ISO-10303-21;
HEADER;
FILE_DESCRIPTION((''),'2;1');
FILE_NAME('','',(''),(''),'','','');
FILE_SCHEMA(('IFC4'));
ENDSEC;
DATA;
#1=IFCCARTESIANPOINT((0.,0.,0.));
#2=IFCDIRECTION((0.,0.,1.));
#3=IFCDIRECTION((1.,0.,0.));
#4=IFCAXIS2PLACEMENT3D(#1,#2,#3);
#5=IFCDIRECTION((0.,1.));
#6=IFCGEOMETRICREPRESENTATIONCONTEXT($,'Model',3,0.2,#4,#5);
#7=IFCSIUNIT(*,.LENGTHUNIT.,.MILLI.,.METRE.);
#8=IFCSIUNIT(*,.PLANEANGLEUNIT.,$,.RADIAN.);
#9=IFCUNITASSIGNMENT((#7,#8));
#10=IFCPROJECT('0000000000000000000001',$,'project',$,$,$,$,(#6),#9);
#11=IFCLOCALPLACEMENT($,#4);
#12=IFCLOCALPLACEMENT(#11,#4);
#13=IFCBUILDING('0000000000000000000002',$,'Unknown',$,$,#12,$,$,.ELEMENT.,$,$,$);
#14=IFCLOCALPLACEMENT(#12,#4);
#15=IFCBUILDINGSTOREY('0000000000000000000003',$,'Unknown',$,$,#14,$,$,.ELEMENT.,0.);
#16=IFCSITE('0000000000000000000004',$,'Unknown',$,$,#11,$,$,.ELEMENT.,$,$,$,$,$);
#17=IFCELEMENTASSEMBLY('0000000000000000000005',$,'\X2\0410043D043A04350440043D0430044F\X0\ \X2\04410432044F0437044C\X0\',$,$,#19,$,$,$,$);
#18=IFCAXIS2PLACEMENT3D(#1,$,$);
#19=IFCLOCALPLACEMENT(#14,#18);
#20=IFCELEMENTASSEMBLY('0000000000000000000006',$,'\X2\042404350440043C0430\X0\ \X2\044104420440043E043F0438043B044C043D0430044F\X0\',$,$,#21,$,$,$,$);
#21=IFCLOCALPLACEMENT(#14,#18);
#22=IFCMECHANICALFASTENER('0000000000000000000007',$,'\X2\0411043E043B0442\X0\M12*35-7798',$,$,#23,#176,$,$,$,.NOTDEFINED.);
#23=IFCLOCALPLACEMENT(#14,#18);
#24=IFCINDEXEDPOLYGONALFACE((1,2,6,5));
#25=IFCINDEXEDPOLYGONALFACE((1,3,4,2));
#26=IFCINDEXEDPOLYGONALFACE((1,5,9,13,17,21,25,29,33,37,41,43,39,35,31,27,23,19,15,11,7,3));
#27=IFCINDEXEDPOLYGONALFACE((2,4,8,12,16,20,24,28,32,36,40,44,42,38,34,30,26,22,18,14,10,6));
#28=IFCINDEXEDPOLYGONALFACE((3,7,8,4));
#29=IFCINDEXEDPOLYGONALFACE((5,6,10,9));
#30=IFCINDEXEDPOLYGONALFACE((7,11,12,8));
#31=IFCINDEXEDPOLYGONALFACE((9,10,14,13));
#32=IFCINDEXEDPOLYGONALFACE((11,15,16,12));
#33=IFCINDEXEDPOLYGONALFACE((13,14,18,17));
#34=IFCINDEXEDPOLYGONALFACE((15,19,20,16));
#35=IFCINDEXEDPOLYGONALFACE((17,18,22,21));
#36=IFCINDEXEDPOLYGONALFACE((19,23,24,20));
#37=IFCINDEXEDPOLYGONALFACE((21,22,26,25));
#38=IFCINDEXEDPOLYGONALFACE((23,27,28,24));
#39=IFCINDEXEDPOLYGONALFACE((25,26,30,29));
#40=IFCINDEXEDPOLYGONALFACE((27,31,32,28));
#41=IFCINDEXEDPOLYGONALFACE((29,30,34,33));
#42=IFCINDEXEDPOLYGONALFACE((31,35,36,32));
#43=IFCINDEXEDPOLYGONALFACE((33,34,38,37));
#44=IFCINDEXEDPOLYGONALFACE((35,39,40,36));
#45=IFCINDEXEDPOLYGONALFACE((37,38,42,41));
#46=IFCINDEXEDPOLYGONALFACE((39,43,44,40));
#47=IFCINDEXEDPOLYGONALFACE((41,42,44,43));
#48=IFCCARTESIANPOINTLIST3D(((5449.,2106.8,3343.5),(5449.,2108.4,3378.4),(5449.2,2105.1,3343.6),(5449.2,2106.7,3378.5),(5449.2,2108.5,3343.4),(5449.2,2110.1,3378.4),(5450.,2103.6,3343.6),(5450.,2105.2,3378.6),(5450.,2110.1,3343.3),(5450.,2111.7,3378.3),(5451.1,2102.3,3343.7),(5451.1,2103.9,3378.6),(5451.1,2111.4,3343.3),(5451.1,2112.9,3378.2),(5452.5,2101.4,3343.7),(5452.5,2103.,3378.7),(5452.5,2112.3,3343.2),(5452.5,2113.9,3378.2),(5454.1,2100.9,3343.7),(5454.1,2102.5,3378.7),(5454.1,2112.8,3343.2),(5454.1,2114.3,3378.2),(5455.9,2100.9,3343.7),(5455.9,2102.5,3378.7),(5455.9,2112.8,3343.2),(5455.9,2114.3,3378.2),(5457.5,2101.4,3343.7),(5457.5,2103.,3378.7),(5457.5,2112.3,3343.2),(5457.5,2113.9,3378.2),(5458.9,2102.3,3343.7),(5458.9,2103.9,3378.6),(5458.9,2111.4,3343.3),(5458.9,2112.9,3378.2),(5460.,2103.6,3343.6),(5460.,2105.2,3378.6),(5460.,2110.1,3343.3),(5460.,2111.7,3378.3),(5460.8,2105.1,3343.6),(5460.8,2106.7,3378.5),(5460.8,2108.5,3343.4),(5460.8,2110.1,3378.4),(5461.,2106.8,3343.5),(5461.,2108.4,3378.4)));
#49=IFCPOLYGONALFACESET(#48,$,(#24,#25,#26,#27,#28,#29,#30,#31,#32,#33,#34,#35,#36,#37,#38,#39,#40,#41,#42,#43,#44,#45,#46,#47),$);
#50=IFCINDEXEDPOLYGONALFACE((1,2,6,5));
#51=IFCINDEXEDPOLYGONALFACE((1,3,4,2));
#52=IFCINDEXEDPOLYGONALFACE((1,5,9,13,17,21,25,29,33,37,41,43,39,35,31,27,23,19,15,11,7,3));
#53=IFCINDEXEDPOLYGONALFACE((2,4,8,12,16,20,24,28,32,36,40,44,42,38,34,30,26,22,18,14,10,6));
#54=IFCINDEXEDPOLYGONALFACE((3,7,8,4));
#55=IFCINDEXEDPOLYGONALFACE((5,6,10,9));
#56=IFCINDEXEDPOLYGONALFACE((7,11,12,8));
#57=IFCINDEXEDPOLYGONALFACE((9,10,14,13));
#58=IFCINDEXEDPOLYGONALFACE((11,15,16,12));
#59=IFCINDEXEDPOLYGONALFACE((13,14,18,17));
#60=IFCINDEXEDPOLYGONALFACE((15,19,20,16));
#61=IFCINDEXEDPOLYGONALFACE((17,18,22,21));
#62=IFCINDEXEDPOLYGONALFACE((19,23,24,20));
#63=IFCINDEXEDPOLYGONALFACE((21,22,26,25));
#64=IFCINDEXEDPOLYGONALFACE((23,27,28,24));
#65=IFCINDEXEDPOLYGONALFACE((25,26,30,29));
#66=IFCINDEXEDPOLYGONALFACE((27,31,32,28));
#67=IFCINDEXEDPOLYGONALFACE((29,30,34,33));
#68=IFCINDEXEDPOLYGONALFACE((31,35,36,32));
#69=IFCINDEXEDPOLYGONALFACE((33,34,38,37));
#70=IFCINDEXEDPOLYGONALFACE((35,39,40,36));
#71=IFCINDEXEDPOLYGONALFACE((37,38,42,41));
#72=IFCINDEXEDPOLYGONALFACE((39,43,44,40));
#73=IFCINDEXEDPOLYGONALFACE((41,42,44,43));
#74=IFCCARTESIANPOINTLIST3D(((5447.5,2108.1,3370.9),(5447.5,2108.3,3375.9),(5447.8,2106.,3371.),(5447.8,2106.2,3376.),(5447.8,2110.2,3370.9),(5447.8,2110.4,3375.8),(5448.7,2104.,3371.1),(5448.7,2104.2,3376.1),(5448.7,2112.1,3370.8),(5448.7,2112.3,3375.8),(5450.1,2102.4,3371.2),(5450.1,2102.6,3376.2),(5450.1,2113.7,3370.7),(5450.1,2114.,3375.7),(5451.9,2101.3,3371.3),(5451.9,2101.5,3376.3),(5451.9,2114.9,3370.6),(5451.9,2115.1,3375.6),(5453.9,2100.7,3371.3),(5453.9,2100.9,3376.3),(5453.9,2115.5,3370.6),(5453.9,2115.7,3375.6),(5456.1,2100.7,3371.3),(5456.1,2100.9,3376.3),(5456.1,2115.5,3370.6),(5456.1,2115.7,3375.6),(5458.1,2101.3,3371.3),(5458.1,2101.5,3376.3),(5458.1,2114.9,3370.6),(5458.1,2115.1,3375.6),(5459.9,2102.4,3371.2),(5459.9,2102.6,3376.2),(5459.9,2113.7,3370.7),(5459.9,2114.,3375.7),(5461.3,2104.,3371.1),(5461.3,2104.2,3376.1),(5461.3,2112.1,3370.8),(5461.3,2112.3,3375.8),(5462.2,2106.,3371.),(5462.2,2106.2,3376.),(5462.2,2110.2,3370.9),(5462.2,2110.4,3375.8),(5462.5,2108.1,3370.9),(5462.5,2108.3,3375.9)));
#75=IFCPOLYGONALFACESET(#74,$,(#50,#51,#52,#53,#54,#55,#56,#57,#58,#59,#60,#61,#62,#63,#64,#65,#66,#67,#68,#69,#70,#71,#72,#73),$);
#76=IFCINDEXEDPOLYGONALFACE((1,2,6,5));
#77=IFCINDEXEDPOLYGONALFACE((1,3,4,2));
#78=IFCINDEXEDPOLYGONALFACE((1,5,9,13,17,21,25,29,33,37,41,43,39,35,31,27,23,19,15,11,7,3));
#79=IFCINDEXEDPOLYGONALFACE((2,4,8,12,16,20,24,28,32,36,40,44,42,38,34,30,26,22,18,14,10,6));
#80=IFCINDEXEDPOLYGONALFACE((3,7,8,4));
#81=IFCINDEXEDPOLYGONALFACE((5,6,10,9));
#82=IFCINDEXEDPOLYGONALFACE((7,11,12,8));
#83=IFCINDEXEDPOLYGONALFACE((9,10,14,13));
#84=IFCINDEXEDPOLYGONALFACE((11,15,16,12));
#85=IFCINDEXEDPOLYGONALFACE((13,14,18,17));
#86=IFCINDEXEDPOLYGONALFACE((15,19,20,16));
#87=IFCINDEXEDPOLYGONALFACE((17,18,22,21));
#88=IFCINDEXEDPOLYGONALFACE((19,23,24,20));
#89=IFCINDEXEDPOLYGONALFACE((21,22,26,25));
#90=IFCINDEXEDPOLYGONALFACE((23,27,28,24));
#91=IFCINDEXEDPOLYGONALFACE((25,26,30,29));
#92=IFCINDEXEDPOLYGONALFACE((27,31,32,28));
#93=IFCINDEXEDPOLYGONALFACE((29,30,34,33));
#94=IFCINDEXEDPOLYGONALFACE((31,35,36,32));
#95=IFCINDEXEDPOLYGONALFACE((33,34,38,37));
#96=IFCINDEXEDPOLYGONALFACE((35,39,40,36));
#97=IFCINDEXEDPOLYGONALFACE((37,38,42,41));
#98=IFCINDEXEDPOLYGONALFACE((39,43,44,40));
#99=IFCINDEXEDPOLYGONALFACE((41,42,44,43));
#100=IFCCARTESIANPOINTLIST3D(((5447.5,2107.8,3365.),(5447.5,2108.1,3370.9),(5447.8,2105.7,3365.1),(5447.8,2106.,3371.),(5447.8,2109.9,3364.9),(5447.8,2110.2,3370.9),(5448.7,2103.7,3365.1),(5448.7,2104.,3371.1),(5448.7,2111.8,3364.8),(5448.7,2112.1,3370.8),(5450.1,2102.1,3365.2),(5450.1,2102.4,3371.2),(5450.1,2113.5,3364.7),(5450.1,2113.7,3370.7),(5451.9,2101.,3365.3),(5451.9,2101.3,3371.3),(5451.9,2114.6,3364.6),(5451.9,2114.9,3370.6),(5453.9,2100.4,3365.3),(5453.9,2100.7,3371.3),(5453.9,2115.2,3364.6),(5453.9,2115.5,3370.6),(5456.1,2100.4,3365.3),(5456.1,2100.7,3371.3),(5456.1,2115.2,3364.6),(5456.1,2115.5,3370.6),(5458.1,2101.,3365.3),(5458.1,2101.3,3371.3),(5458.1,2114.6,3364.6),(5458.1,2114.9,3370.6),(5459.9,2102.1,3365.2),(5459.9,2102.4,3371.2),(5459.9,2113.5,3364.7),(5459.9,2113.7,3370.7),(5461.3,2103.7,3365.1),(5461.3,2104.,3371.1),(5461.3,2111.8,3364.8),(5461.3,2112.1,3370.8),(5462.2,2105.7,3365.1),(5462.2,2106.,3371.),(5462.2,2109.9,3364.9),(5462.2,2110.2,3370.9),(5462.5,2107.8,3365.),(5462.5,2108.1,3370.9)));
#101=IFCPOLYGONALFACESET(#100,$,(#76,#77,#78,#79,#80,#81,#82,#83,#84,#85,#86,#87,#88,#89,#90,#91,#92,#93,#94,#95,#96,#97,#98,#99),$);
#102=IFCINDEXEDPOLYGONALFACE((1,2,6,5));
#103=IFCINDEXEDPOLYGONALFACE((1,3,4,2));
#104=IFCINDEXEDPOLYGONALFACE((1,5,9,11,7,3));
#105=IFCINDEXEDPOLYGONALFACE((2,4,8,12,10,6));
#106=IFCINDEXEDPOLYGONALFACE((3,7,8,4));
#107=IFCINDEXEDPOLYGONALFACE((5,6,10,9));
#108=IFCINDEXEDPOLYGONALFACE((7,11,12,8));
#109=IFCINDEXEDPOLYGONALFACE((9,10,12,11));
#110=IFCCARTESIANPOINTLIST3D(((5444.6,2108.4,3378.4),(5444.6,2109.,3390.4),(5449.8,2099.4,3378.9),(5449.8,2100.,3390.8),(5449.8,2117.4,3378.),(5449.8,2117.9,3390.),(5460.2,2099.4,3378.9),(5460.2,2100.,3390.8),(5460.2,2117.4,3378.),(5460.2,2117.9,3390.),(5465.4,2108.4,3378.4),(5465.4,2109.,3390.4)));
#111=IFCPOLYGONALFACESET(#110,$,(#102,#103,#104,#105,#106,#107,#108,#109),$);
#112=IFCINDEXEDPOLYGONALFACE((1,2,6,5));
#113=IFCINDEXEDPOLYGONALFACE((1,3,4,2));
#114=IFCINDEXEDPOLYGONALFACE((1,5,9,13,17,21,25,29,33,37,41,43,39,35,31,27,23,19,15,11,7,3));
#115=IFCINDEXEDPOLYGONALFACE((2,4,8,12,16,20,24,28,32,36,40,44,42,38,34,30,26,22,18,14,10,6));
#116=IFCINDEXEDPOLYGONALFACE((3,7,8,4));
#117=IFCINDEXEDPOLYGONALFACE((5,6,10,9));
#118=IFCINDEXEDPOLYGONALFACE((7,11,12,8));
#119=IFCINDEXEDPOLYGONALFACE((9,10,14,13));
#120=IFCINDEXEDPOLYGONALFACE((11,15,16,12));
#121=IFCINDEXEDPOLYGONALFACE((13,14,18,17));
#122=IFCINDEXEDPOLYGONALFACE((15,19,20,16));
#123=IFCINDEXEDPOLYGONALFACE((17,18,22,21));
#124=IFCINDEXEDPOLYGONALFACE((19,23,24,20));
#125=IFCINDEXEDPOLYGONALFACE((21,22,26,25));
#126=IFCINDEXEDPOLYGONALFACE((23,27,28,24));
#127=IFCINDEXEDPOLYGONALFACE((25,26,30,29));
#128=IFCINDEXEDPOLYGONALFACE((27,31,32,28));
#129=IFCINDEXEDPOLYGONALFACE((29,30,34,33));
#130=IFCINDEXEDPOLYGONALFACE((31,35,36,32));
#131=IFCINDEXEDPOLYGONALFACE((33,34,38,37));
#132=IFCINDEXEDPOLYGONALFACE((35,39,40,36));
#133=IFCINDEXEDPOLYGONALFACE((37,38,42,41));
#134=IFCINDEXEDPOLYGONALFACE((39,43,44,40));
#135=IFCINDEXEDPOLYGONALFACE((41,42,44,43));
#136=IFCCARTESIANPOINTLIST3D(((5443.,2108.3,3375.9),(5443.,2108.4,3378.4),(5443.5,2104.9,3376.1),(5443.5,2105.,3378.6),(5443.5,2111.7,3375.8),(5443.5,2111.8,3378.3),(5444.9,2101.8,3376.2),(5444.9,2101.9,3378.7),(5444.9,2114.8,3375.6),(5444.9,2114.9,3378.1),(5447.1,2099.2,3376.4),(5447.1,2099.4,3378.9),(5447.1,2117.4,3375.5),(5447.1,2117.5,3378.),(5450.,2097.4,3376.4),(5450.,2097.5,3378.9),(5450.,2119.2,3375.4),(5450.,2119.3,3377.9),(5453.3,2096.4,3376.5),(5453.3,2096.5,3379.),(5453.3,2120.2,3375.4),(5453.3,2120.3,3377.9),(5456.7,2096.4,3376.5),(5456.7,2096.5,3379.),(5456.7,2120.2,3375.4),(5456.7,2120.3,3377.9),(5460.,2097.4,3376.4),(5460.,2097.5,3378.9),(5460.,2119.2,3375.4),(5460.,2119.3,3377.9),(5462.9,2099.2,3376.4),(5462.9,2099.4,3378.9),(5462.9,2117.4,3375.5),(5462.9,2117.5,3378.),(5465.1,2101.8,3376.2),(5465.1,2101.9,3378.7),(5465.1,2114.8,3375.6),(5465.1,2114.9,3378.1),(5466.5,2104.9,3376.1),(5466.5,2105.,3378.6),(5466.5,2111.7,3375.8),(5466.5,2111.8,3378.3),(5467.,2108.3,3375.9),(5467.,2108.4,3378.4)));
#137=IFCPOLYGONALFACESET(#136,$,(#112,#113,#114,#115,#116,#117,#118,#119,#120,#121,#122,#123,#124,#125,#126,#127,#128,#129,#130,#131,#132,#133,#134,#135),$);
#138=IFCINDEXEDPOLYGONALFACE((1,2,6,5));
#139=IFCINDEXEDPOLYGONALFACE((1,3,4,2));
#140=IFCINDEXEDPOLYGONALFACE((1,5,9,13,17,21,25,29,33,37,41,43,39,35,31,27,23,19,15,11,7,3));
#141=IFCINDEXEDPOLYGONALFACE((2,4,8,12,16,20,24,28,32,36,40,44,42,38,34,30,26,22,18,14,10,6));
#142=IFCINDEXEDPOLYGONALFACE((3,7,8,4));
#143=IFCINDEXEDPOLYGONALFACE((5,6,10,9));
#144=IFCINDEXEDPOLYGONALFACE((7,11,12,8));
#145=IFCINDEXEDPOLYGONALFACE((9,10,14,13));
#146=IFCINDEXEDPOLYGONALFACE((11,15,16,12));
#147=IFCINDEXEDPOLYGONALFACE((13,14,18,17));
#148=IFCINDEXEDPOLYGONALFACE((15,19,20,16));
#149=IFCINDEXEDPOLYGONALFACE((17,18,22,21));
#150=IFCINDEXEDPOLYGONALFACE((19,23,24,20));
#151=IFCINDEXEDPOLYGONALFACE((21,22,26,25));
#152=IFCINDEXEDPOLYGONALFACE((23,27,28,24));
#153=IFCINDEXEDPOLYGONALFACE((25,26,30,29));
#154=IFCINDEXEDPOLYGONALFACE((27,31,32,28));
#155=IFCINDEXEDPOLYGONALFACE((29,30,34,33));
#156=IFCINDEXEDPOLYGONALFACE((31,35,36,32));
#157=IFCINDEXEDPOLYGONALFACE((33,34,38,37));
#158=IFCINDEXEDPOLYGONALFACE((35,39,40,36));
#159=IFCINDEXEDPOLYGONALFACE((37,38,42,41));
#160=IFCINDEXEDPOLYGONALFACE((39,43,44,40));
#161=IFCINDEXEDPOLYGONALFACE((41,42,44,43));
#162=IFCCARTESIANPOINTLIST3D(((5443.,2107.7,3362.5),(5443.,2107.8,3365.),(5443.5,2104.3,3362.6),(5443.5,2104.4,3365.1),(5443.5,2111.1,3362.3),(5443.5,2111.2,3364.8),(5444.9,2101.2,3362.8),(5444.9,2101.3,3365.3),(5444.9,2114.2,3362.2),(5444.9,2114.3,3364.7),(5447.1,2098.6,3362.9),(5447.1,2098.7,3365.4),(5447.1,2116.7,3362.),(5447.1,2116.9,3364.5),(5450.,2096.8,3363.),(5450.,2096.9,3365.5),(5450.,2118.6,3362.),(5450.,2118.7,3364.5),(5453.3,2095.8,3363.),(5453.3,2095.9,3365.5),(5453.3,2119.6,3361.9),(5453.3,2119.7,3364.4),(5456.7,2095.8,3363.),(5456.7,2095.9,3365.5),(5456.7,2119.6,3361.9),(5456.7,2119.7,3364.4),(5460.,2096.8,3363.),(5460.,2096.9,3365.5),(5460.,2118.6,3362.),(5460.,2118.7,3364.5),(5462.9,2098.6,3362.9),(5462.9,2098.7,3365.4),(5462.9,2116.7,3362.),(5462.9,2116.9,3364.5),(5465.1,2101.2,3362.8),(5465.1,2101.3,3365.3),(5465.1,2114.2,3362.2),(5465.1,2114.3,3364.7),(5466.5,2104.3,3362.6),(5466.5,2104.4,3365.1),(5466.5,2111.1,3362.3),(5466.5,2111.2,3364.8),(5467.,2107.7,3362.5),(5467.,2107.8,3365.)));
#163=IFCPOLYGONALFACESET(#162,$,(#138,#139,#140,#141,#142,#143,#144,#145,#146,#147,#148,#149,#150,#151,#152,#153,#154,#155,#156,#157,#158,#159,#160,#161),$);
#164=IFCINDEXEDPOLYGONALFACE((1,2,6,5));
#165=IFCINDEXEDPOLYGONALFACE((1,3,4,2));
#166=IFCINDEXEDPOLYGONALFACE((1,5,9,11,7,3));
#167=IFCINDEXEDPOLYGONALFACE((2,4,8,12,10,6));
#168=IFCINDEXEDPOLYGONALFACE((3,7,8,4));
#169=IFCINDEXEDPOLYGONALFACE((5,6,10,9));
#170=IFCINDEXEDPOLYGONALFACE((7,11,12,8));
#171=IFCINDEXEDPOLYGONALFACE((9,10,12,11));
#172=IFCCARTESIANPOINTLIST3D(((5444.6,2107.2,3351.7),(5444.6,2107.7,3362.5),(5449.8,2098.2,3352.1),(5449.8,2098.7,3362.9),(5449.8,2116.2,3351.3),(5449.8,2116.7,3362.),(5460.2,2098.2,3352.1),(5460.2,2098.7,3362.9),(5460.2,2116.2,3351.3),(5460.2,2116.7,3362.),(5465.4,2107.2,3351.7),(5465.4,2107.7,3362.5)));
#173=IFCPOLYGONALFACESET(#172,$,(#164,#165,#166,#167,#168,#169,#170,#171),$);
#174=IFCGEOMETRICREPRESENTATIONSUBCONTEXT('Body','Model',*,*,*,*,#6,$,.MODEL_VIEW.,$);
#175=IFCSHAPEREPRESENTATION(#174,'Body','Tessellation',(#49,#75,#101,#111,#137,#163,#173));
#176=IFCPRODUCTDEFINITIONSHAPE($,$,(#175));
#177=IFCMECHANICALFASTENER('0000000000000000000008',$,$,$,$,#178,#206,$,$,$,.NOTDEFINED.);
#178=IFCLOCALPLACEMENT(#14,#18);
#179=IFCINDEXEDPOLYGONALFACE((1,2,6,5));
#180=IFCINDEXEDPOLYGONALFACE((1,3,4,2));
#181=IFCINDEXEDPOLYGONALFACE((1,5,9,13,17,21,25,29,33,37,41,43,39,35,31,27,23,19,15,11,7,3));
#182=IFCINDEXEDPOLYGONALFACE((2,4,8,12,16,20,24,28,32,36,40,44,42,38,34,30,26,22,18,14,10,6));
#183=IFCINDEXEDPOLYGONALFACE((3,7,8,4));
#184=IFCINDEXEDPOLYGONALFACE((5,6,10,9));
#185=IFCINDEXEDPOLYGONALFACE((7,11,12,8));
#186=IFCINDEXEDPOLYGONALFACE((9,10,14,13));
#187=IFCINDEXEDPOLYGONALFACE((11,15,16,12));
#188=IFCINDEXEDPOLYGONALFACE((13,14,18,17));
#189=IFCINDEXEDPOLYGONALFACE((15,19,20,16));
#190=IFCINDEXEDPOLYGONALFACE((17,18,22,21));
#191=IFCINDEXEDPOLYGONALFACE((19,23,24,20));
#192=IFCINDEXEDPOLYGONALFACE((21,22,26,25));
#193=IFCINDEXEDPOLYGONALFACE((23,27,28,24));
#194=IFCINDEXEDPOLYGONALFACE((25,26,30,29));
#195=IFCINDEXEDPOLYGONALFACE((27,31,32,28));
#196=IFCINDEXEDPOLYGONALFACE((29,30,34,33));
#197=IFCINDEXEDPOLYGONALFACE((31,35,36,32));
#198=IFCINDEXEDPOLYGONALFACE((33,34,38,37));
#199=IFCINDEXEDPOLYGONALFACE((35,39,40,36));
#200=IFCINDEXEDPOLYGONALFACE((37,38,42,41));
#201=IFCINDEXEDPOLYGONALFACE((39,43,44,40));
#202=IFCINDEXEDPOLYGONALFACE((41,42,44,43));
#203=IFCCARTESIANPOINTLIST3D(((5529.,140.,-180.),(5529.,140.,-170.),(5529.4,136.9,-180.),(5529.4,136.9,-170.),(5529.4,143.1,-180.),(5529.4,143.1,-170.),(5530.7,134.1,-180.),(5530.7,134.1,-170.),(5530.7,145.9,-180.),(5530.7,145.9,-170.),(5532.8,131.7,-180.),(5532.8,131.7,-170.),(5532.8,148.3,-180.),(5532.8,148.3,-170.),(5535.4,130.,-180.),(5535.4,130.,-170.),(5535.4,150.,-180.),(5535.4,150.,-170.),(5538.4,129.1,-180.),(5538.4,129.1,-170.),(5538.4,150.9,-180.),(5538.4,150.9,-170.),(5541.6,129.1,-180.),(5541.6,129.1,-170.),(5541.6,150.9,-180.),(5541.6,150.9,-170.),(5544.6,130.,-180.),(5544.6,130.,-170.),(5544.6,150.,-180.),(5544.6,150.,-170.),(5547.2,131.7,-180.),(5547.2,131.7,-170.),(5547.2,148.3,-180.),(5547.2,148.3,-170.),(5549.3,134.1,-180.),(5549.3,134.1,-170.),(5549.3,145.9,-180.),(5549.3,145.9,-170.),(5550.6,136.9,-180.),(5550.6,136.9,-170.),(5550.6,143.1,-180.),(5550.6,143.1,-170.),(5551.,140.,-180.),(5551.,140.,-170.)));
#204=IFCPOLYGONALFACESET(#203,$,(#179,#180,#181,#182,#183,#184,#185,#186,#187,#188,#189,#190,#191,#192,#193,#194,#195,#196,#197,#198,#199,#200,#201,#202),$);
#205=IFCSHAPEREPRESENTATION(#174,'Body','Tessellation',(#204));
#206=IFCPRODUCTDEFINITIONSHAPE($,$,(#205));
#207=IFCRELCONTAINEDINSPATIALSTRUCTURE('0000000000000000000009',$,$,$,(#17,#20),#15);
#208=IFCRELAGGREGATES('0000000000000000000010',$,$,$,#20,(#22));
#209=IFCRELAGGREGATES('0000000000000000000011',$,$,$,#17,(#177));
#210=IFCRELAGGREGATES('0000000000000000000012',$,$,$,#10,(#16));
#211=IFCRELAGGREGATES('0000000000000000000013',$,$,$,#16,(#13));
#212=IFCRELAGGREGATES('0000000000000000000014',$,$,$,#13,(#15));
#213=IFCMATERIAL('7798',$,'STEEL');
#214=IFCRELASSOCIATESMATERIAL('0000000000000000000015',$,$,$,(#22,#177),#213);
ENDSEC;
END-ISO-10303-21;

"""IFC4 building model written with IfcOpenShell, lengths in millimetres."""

from ifc_helpers import new_model, si_unit, direction, frame, origin_with_axes, place, context, subcontext, project, spatial, line, arc, indexed_curve, outline, extrude, source, transform, mapped, material, element, aggregate, save


model = new_model("IFC4")

# Units and contexts
model_context = context("Model", 3, precision=0.2, world=origin_with_axes(), true_north=direction((0.0, 1.0)))
body_context = subcontext(model_context, "Body", "Model", "MODEL_VIEW")
ifc_project = project(units=[si_unit("LENGTHUNIT", "METRE", prefix="MILLI"), si_unit("PLANEANGLEUNIT", "RADIAN")], contexts=[model_context])

# Site, building, storey
site_placement = place(None, origin_with_axes())
site = spatial("IfcSite", under=ifc_project, at=site_placement, Name="Unknown", CompositionType="ELEMENT")
building_placement = place(site_placement, origin_with_axes())
building = spatial("IfcBuilding", under=site, at=building_placement, Name="Unknown", CompositionType="ELEMENT")
storey_placement = place(building_placement, origin_with_axes())
storey = spatial("IfcBuildingStorey", under=building, at=storey_placement, Name="Unknown", CompositionType="ELEMENT", Elevation=0.0)

# Element assembly
assembly_1_placement = place(storey_placement, frame((5540.0, 140.0, -125.0), z_axis=(-1.0, 0.0, 0.0), x_axis=(0.0, 0.0, -1.0)))
assembly_1 = element("IfcElementAssembly", 1, at=assembly_1_placement, inside=storey, Name="Анкерная связь")

# Element assembly
assembly_2_placement = place(storey_placement, frame((5400.0, 88.6, 3426.7), z_axis=(1.0, 0.0, 0.0), x_axis=(0.0, 0.998969, -0.045408)))
assembly_2 = element("IfcElementAssembly", 2, at=assembly_2_placement, inside=storey, Name="Ферма стропильная")

# Mechanical fasteners
ifc_material_1 = material(Name="7798", Category="STEEL")
shared_shape_1 = source(origin_with_axes(), body_context, "Body", "SweptSolid", [
    extrude(outline(indexed_curve([(6.0, 0.0), (0.0, 6.0), (-6.0, 0.0), (0.0, -6.0)], segments=[arc(1, 2, 3), arc(3, 4, 1)])), frame((0.0, 0.0, 7.5), z_axis=(0.0, 0.0, -1.0), x_axis=(0.0, 1.0, 0.0)), (0.0, 0.0, 1.0), 35.0),
    extrude(outline(indexed_curve([(7.5, 0.0), (0.0, 7.5), (-7.5, 0.0), (0.0, -7.5)], segments=[arc(1, 2, 3), arc(3, 4, 1)])), frame((0.0, 0.0, 5.0), z_axis=(0.0, 0.0, -1.0), x_axis=(0.0, 1.0, 0.0)), (0.0, 0.0, 1.0), 5.0),
    extrude(outline(indexed_curve([(7.5, 0.0), (0.0, 7.5), (-7.5, 0.0), (0.0, -7.5)], segments=[arc(1, 2, 3), arc(3, 4, 1)])), frame((0.0, 0.0, 0.0), z_axis=(0.0, 0.0, -1.0), x_axis=(0.0, 1.0, 0.0)), (0.0, 0.0, 1.0), 6.0),
    extrude(outline(indexed_curve([(10.4, 0.0), (5.2, 9.0), (-5.2, 9.0), (-10.4, 0.0), (-5.2, -9.0), (5.2, -9.0)], segments=[line(1, 2, 3, 4, 5, 6, 1)])), frame((0.0, 0.0, 19.5), z_axis=(0.0, 0.0, -1.0), x_axis=(0.0, 1.0, 0.0)), (0.0, 0.0, 1.0), 12.0),
    extrude(outline(indexed_curve([(12.0, 0.0), (0.0, 12.0), (-12.0, 0.0), (0.0, -12.0)], segments=[arc(1, 2, 3), arc(3, 4, 1)])), frame((0.0, 0.0, 7.5), z_axis=(0.0, 0.0, -1.0), x_axis=(0.0, 1.0, 0.0)), (0.0, 0.0, 1.0), 2.5),
    extrude(outline(indexed_curve([(12.0, 0.0), (0.0, 12.0), (-12.0, 0.0), (0.0, -12.0)], segments=[arc(1, 2, 3), arc(3, 4, 1)])), frame((0.0, 0.0, -6.0), z_axis=(0.0, 0.0, -1.0), x_axis=(0.0, 1.0, 0.0)), (0.0, 0.0, 1.0), 2.5),
    extrude(outline(indexed_curve([(10.4, 0.0), (5.2, 9.0), (-5.2, 9.0), (-10.4, 0.0), (-5.2, -9.0), (5.2, -9.0)], segments=[line(1, 2, 3, 4, 5, 6, 1)])), frame((0.0, 0.0, -8.5), z_axis=(0.0, 0.0, -1.0), x_axis=(0.0, 1.0, 0.0)), (0.0, 0.0, 1.0), 10.8),
])
mechanical_fastener_1_placement = place(assembly_2_placement, frame((2019.9, 36.0, 55.0), z_axis=(0.0, 1.0, 0.0), x_axis=(1.0, 0.0, 0.0)))
mechanical_fastener_1 = element("IfcMechanicalFastener", 3, at=mechanical_fastener_1_placement, material=ifc_material_1, Name="БолтM12*35-7798", PredefinedType="NOTDEFINED", context=body_context, shape_type="MappedRepresentation", body=[
    mapped(shared_shape_1, transform((0.0, 0.0, 0.0))),
])
aggregate(assembly_2, [mechanical_fastener_1])
shared_shape_2 = source(origin_with_axes(), body_context, "Body", "SweptSolid", [
    extrude(outline(indexed_curve([(11.0, 0.0), (0.0, 11.0), (-11.0, 0.0), (0.0, -11.0)], segments=[arc(1, 2, 3), arc(3, 4, 1)])), frame((0.0, 0.0, 0.0), z_axis=(0.0, 0.0, -1.0), x_axis=(0.0, 1.0, 0.0)), (0.0, 0.0, 1.0), 10.0),
])
mechanical_fastener_2_placement = place(assembly_1_placement, frame((55.0, 0.0, 0.0), z_axis=(1.0, 0.0, 0.0), x_axis=(0.0, -1.0, 0.0)))
mechanical_fastener_2 = element("IfcMechanicalFastener", 4, at=mechanical_fastener_2_placement, material=ifc_material_1, PredefinedType="NOTDEFINED", context=body_context, shape_type="MappedRepresentation", body=[
    mapped(shared_shape_2, transform((0.0, 0.0, 0.0))),
])
aggregate(assembly_1, [mechanical_fastener_2])

save(model, "model.ifc")
